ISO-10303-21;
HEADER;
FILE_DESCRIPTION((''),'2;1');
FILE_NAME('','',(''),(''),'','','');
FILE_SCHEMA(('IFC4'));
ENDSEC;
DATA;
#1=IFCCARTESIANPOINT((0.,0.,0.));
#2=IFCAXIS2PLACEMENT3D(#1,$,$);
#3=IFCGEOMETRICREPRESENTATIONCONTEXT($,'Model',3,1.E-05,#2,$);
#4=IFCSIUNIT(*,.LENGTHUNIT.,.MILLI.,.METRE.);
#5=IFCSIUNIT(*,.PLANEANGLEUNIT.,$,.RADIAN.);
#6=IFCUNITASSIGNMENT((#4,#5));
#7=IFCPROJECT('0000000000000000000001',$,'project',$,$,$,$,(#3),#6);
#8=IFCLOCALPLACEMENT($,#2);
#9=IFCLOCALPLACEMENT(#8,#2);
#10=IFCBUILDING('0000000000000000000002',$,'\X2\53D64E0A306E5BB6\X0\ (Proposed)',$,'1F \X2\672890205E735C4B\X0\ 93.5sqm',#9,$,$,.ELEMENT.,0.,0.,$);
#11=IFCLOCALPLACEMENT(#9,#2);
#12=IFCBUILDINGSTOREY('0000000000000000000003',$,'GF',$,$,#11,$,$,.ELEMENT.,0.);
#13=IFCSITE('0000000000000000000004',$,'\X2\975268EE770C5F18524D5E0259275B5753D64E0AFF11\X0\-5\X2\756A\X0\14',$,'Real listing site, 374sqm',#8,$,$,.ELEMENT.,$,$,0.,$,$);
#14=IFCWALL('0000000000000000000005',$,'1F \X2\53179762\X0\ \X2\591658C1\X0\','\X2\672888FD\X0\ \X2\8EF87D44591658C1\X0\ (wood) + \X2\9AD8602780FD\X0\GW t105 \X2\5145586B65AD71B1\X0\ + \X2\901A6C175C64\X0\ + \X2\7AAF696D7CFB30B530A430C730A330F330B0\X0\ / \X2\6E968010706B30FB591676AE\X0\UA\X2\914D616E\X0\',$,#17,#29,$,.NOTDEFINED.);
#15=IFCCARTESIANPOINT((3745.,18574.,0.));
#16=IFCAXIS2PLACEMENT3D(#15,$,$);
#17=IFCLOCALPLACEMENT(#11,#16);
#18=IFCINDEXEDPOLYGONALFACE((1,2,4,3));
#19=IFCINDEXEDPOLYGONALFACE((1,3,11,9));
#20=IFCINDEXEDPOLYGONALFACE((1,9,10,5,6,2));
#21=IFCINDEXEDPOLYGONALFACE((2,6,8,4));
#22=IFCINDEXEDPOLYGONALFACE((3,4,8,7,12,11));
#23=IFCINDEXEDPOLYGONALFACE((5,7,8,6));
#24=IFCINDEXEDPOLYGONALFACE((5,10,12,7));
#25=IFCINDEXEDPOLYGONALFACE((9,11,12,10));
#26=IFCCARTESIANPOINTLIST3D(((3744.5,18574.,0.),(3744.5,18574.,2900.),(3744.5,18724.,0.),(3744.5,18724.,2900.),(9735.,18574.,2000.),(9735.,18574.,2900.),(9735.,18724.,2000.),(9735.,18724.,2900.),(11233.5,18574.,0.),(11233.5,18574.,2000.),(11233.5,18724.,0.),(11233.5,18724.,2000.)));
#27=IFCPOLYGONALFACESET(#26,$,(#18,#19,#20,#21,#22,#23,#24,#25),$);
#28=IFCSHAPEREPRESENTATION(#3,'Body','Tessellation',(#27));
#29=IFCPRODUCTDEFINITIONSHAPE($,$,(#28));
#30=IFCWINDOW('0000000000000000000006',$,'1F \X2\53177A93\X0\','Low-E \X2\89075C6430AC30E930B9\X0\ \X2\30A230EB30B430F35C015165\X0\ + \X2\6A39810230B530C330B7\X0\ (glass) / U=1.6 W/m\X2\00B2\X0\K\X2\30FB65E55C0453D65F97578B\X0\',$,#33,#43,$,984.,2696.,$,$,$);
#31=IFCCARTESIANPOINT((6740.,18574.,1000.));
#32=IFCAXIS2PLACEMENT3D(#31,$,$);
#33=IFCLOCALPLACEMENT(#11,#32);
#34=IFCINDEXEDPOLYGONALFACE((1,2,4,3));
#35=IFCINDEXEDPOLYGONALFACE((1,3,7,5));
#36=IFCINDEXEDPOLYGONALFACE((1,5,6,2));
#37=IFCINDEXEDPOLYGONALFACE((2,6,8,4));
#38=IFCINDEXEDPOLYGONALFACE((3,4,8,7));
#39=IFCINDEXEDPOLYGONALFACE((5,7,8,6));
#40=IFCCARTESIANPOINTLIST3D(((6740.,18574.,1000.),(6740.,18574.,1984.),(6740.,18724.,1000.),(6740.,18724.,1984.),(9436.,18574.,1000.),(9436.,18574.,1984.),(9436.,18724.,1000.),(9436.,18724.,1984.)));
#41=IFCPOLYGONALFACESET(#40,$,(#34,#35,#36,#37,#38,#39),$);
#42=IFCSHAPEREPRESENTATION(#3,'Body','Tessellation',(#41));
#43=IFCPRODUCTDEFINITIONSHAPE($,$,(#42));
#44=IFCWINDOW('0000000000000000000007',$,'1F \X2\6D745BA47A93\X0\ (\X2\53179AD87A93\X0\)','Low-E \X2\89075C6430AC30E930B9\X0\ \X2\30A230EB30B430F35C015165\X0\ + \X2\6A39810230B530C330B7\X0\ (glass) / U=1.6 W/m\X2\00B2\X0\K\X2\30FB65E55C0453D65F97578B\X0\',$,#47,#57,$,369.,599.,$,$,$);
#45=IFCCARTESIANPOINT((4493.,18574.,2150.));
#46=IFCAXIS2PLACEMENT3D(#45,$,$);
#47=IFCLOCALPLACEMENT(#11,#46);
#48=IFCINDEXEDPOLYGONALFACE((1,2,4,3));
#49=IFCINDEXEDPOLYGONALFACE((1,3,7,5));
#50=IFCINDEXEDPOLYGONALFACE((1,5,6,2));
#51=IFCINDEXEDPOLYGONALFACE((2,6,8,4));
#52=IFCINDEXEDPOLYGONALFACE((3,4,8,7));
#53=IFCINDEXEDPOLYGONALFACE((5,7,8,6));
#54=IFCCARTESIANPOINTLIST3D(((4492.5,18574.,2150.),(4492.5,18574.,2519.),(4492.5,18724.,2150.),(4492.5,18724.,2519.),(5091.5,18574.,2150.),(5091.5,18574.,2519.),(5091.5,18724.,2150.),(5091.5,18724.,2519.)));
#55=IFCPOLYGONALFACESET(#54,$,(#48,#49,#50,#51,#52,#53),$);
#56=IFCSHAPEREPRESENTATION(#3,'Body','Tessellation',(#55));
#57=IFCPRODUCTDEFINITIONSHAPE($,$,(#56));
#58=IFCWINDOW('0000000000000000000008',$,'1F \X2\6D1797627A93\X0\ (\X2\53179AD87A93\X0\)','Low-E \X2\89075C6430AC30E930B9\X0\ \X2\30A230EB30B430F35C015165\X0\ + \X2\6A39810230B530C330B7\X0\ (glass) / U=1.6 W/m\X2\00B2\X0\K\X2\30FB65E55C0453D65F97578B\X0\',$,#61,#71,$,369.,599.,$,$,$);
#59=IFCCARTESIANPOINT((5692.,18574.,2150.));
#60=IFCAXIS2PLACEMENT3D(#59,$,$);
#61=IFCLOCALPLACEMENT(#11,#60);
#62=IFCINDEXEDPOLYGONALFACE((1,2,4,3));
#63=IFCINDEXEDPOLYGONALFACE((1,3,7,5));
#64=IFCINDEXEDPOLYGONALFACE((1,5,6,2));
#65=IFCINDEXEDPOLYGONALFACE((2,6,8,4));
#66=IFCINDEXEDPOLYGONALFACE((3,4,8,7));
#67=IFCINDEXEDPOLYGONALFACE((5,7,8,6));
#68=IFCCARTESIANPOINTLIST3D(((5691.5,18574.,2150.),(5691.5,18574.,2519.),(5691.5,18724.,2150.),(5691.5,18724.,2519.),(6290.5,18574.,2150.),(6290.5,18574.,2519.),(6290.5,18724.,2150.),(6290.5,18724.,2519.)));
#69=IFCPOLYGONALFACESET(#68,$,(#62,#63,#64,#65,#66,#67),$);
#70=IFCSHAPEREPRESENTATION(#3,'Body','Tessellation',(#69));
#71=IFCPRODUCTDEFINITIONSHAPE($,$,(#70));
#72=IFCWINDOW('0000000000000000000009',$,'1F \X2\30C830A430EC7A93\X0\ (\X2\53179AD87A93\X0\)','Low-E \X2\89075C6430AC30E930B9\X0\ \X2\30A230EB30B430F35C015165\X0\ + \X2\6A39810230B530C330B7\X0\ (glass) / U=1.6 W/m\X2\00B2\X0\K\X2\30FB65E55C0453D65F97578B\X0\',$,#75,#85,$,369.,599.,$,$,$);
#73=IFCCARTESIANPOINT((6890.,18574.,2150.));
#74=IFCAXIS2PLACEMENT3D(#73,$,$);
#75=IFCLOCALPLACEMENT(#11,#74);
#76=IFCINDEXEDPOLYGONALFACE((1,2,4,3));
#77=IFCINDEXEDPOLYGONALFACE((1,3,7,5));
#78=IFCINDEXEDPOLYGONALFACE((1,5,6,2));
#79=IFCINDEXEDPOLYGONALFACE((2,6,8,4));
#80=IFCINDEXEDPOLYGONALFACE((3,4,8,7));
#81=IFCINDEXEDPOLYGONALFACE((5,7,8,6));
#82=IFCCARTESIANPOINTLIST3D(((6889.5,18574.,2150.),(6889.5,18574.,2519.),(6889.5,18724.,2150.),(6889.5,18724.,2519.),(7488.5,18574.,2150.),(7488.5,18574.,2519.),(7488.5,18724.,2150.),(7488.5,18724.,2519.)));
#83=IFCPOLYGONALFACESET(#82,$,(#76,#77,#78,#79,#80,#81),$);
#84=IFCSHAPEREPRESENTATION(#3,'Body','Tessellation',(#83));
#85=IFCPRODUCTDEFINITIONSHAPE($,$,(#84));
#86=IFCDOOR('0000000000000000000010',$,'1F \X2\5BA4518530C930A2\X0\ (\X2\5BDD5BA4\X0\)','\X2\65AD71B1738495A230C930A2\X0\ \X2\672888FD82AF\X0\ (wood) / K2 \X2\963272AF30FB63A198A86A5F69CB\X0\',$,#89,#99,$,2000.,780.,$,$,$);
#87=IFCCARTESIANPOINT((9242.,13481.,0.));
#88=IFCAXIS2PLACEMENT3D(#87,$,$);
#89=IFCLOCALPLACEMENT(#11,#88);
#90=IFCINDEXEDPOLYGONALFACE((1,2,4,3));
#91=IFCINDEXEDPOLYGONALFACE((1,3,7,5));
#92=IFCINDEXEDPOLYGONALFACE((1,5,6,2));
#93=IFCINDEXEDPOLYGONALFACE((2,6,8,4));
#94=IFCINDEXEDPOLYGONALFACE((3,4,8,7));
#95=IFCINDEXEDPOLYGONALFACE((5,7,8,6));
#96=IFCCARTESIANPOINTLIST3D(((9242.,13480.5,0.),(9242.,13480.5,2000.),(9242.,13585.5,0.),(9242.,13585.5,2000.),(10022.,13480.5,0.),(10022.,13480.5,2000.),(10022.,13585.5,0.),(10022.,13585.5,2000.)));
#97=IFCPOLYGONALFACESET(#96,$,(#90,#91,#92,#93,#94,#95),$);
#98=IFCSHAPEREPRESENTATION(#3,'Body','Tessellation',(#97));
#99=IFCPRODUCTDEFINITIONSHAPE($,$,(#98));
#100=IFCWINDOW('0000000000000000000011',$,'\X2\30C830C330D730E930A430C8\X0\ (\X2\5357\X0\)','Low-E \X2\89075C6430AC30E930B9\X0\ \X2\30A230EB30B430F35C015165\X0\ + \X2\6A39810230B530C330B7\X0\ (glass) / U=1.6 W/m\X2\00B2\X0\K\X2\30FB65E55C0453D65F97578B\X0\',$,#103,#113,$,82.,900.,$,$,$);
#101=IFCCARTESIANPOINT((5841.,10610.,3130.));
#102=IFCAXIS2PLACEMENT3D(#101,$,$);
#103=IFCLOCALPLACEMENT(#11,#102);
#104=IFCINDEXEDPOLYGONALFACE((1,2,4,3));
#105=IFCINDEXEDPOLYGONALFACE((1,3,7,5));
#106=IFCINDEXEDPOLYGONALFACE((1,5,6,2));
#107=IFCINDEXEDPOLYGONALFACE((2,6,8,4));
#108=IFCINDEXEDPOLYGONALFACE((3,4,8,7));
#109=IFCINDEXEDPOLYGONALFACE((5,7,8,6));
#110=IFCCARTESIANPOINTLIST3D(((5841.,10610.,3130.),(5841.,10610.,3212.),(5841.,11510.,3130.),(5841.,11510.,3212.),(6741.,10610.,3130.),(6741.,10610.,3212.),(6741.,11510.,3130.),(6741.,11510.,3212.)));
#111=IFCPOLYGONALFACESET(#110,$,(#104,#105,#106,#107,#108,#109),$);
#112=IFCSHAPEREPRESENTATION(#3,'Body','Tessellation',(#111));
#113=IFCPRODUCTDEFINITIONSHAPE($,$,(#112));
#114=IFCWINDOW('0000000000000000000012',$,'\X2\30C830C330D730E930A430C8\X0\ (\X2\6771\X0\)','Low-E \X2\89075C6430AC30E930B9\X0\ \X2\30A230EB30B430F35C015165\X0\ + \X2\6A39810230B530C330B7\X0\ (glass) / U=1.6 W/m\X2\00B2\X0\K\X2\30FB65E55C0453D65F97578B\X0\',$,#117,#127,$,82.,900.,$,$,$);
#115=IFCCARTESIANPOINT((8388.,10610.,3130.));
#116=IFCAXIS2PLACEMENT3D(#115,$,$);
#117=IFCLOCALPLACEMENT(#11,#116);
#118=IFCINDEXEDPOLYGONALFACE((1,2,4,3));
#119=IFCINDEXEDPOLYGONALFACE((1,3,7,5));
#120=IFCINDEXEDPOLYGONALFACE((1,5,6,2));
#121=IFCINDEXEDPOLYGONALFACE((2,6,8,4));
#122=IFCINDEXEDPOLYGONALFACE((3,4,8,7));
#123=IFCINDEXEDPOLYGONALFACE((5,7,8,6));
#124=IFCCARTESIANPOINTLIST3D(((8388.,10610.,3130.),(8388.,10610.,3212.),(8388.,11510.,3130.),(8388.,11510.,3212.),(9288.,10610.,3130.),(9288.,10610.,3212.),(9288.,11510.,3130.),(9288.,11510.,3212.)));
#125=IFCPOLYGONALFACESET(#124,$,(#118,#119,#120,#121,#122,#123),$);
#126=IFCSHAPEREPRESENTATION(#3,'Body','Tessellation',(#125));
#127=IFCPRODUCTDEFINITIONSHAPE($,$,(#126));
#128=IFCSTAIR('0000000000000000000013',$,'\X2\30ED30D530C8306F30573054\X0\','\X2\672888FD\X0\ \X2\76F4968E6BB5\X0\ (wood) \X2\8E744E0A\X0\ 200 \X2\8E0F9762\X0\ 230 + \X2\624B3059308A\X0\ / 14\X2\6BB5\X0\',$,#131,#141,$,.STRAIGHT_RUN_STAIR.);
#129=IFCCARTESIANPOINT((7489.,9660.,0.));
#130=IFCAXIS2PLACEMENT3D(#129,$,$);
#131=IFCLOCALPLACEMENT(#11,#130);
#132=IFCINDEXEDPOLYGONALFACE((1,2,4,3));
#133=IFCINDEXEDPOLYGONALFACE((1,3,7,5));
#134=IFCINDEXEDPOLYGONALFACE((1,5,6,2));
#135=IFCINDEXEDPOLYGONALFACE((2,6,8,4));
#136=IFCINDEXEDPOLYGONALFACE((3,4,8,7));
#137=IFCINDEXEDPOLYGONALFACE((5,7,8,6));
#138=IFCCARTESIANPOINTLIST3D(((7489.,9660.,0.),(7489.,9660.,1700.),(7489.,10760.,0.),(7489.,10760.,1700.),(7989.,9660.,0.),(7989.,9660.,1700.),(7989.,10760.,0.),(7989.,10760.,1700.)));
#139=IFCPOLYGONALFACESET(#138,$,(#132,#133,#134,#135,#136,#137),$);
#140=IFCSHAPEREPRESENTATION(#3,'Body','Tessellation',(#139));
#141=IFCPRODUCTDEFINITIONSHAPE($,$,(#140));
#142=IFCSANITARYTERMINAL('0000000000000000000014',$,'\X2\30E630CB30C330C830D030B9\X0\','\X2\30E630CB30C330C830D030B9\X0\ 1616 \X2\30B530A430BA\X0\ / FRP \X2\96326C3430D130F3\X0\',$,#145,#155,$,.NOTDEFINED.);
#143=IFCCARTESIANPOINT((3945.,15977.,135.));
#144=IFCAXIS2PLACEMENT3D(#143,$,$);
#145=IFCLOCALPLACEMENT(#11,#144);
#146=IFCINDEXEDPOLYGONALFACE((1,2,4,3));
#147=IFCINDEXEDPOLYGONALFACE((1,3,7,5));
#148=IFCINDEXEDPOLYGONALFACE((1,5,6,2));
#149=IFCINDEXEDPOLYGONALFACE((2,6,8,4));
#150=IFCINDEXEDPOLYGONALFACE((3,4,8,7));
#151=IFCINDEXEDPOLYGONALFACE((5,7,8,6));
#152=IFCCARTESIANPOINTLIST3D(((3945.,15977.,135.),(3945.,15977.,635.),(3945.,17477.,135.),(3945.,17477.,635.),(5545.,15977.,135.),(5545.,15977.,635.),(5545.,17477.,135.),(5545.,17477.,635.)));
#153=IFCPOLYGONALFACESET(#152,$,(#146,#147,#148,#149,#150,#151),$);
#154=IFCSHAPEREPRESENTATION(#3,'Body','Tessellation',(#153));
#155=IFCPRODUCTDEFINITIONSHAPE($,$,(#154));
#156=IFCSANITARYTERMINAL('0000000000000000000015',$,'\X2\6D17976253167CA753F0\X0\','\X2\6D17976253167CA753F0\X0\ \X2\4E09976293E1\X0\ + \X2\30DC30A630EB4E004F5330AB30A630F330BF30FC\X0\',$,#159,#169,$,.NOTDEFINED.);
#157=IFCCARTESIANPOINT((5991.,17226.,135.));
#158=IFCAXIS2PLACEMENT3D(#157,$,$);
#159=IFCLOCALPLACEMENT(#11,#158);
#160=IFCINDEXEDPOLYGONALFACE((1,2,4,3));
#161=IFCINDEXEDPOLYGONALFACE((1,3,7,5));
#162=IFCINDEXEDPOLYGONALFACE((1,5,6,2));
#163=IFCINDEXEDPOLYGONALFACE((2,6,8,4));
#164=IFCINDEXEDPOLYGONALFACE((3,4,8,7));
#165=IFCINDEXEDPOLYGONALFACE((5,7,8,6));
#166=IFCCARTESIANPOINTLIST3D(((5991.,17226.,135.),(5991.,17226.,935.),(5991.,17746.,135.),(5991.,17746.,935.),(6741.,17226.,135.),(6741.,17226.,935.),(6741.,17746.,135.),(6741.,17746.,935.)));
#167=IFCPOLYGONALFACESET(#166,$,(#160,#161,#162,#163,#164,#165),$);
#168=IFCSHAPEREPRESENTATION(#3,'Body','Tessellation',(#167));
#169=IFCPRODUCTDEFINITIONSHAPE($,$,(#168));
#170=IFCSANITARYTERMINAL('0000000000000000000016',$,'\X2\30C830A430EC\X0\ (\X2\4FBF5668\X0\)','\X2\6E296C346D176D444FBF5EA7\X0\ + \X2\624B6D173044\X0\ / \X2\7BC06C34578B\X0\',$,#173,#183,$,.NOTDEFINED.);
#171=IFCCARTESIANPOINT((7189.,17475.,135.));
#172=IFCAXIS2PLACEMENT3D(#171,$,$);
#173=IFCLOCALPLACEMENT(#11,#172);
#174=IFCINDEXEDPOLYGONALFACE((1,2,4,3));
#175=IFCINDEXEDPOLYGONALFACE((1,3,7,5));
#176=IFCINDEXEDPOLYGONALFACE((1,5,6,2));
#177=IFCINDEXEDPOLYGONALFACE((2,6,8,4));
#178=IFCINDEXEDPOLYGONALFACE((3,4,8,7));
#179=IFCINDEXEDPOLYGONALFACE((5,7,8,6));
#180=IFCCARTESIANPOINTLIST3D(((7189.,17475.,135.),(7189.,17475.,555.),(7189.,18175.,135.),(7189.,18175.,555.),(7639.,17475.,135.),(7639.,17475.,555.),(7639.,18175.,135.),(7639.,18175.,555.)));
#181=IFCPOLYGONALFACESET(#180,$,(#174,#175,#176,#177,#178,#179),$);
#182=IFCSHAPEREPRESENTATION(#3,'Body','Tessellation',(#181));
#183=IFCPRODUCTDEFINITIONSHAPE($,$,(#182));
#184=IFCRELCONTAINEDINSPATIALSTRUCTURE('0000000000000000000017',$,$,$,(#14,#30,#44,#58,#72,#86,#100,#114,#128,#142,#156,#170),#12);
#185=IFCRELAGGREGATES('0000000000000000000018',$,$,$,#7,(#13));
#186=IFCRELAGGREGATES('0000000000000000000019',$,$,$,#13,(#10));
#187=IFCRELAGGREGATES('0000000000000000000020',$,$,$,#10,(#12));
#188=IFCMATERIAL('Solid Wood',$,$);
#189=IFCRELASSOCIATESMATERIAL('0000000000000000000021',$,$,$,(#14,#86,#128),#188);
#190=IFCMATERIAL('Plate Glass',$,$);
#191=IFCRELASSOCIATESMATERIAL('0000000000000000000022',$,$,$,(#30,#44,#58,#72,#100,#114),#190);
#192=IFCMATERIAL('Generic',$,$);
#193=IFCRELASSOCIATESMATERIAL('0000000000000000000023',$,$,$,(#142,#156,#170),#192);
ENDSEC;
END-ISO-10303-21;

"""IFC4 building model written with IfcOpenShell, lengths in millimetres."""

from ifc_helpers import new_model, si_unit, frame, frame_2d, origin, place, context, project, spatial, rectangle, extrude, material, element, fill, save


model = new_model("IFC4")

# Units and contexts
model_context = context("Model", 3, precision=1e-05, world=origin())
ifc_project = project(units=[si_unit("LENGTHUNIT", "METRE", prefix="MILLI"), si_unit("PLANEANGLEUNIT", "RADIAN")], contexts=[model_context])

# Site, building, storey
site_placement = place(None, origin())
site = spatial("IfcSite", under=ifc_project, at=site_placement, Name="青森県弘前市大字取上１-5番14", ObjectType="Real listing site, 374sqm", CompositionType="ELEMENT", RefElevation=0.0)
building_placement = place(site_placement, origin())
building = spatial("IfcBuilding", under=site, at=building_placement, Name="取上の家 (Proposed)", ObjectType="1F 木造平屋 93.5sqm", CompositionType="ELEMENT", ElevationOfRefHeight=0.0, ElevationOfTerrain=0.0)
storey_placement = place(building_placement, origin())
storey = spatial("IfcBuildingStorey", under=building, at=storey_placement, Name="GF", CompositionType="ELEMENT", Elevation=0.0)

# Shared definitions
ifc_material_1 = material(Name="Solid Wood")

# Wall, openings, windows
wall_1_placement = place(storey_placement, frame((3745.0, 18574.0, 0.0)))
wall_1 = element("IfcWall", 1, at=wall_1_placement, inside=storey, material=ifc_material_1, Name="1F 北面 外壁", Description="木製 軸組外壁 (wood) + 高性能GW t105 充填断熱 + 通気層 + 窯業系サイディング / 準耐火・外皮UA配慮", PredefinedType="NOTDEFINED", context=model_context, shape_type="SweptSolid", body=[
    extrude(rectangle(XDim=7489.0, YDim=150.0, at=frame_2d((3744.0, 75.0))), frame((3745.0, 18574.0, 0.0)), (0.0, 0.0, 1.0), 2900.0),
])
opening_1_placement = place(storey_placement, frame((6740.0, 18574.0, 1000.0)))
opening_1 = element("IfcOpeningElement", 2, at=opening_1_placement, cuts=wall_1, PredefinedType="NOTDEFINED", context=model_context, shape_type="SweptSolid", body=[
    extrude(rectangle(XDim=2696.0, YDim=150.0, at=frame_2d((1348.0, 75.0))), frame((6740.0, 18574.0, 1000.0)), (0.0, 0.0, 1.0), 984.0),
])
opening_2_placement = place(storey_placement, frame((4493.0, 18574.0, 2150.0)))
opening_2 = element("IfcOpeningElement", 3, at=opening_2_placement, cuts=wall_1, PredefinedType="NOTDEFINED", context=model_context, shape_type="SweptSolid", body=[
    extrude(rectangle(XDim=599.0, YDim=150.0, at=frame_2d((299.0, 75.0))), frame((4493.0, 18574.0, 2150.0)), (0.0, 0.0, 1.0), 369.0),
])
opening_3_placement = place(storey_placement, frame((5692.0, 18574.0, 2150.0)))
opening_3 = element("IfcOpeningElement", 4, at=opening_3_placement, cuts=wall_1, PredefinedType="NOTDEFINED", context=model_context, shape_type="SweptSolid", body=[
    extrude(rectangle(XDim=599.0, YDim=150.0, at=frame_2d((299.0, 75.0))), frame((5692.0, 18574.0, 2150.0)), (0.0, 0.0, 1.0), 369.0),
])
opening_4_placement = place(storey_placement, frame((6890.0, 18574.0, 2150.0)))
opening_4 = element("IfcOpeningElement", 5, at=opening_4_placement, cuts=wall_1, PredefinedType="NOTDEFINED", context=model_context, shape_type="SweptSolid", body=[
    extrude(rectangle(XDim=599.0, YDim=150.0, at=frame_2d((299.0, 75.0))), frame((6890.0, 18574.0, 2150.0)), (0.0, 0.0, 1.0), 369.0),
])
ifc_material_2 = material(Name="Plate Glass")
window_1_placement = place(storey_placement, frame((6740.0, 18574.0, 1000.0)))
window_1 = element("IfcWindow", 6, at=window_1_placement, inside=storey, material=ifc_material_2, Name="1F 北窓", Description="Low-E 複層ガラス アルゴン封入 + 樹脂サッシ (glass) / U=1.6 W/m²K・日射取得型", OverallHeight=984.0, OverallWidth=2696.0, context=model_context, shape_type="SweptSolid", body=[
    extrude(rectangle(XDim=2696.0, YDim=150.0, at=frame_2d((1348.0, 75.0))), frame((6740.0, 18574.0, 1000.0)), (0.0, 0.0, 1.0), 984.0),
])
fill(opening_1, window_1)
window_2_placement = place(storey_placement, frame((4493.0, 18574.0, 2150.0)))
window_2 = element("IfcWindow", 7, at=window_2_placement, inside=storey, material=ifc_material_2, Name="1F 浴室窓 (北高窓)", Description="Low-E 複層ガラス アルゴン封入 + 樹脂サッシ (glass) / U=1.6 W/m²K・日射取得型", OverallHeight=369.0, OverallWidth=599.0, context=model_context, shape_type="SweptSolid", body=[
    extrude(rectangle(XDim=599.0, YDim=150.0, at=frame_2d((299.0, 75.0))), frame((4493.0, 18574.0, 2150.0)), (0.0, 0.0, 1.0), 369.0),
])
fill(opening_2, window_2)
window_3_placement = place(storey_placement, frame((5692.0, 18574.0, 2150.0)))
window_3 = element("IfcWindow", 8, at=window_3_placement, inside=storey, material=ifc_material_2, Name="1F 洗面窓 (北高窓)", Description="Low-E 複層ガラス アルゴン封入 + 樹脂サッシ (glass) / U=1.6 W/m²K・日射取得型", OverallHeight=369.0, OverallWidth=599.0, context=model_context, shape_type="SweptSolid", body=[
    extrude(rectangle(XDim=599.0, YDim=150.0, at=frame_2d((299.0, 75.0))), frame((5692.0, 18574.0, 2150.0)), (0.0, 0.0, 1.0), 369.0),
])
fill(opening_3, window_3)
window_4_placement = place(storey_placement, frame((6890.0, 18574.0, 2150.0)))
window_4 = element("IfcWindow", 9, at=window_4_placement, inside=storey, material=ifc_material_2, Name="1F トイレ窓 (北高窓)", Description="Low-E 複層ガラス アルゴン封入 + 樹脂サッシ (glass) / U=1.6 W/m²K・日射取得型", OverallHeight=369.0, OverallWidth=599.0, context=model_context, shape_type="SweptSolid", body=[
    extrude(rectangle(XDim=599.0, YDim=150.0, at=frame_2d((299.0, 75.0))), frame((6890.0, 18574.0, 2150.0)), (0.0, 0.0, 1.0), 369.0),
])
fill(opening_4, window_4)

# Door
door_1_placement = place(storey_placement, frame((9242.0, 13481.0, 0.0)))
element("IfcDoor", 10, at=door_1_placement, inside=storey, material=ifc_material_1, Name="1F 室内ドア (寝室)", Description="断熱玄関ドア 木製芯 (wood) / K2 防犯・採風機構", OverallHeight=2000.0, OverallWidth=780.0, context=model_context, shape_type="SweptSolid", body=[
    extrude(rectangle(XDim=780.0, YDim=105.0, at=frame_2d((390.0, 52.0))), frame((9242.0, 13481.0, 0.0)), (0.0, 0.0, 1.0), 2000.0),
])

# Windows
window_5_placement = place(storey_placement, frame((5841.0, 10610.0, 3130.0)))
element("IfcWindow", 11, at=window_5_placement, inside=storey, material=ifc_material_2, Name="トップライト (南)", Description="Low-E 複層ガラス アルゴン封入 + 樹脂サッシ (glass) / U=1.6 W/m²K・日射取得型", OverallHeight=82.0, OverallWidth=900.0, context=model_context, shape_type="SweptSolid", body=[
    extrude(rectangle(XDim=900.0, YDim=900.0, at=frame_2d((450.0, 450.0))), frame((5841.0, 10610.0, 3130.0)), (0.0, 0.0, 1.0), 82.0),
])
window_6_placement = place(storey_placement, frame((8388.0, 10610.0, 3130.0)))
element("IfcWindow", 12, at=window_6_placement, inside=storey, material=ifc_material_2, Name="トップライト (東)", Description="Low-E 複層ガラス アルゴン封入 + 樹脂サッシ (glass) / U=1.6 W/m²K・日射取得型", OverallHeight=82.0, OverallWidth=900.0, context=model_context, shape_type="SweptSolid", body=[
    extrude(rectangle(XDim=900.0, YDim=900.0, at=frame_2d((450.0, 450.0))), frame((8388.0, 10610.0, 3130.0)), (0.0, 0.0, 1.0), 82.0),
])

# Stair
stair_placement = place(storey_placement, frame((7489.0, 9660.0, 0.0)))
element("IfcStair", 13, at=stair_placement, inside=storey, material=ifc_material_1, Name="ロフトはしご", Description="木製 直階段 (wood) 蹴上 200 踏面 230 + 手すり / 14段", PredefinedType="STRAIGHT_RUN_STAIR", context=model_context, shape_type="SweptSolid", body=[
    extrude(rectangle(XDim=500.0, YDim=1100.0, at=frame_2d((250.0, 550.0))), frame((7489.0, 9660.0, 0.0)), (0.0, 0.0, 1.0), 1700.0),
])

# Sanitary terminals
ifc_material_3 = material(Name="Generic")
sanitary_terminal_1_placement = place(storey_placement, frame((3945.0, 15977.0, 135.0)))
element("IfcSanitaryTerminal", 14, at=sanitary_terminal_1_placement, inside=storey, material=ifc_material_3, Name="ユニットバス", Description="ユニットバス 1616 サイズ / FRP 防水パン", PredefinedType="NOTDEFINED", context=model_context, shape_type="SweptSolid", body=[
    extrude(rectangle(XDim=1600.0, YDim=1500.0, at=frame_2d((800.0, 750.0))), frame((3945.0, 15977.0, 135.0)), (0.0, 0.0, 1.0), 500.0),
])
sanitary_terminal_2_placement = place(storey_placement, frame((5991.0, 17226.0, 135.0)))
element("IfcSanitaryTerminal", 15, at=sanitary_terminal_2_placement, inside=storey, material=ifc_material_3, Name="洗面化粧台", Description="洗面化粧台 三面鏡 + ボウル一体カウンター", PredefinedType="NOTDEFINED", context=model_context, shape_type="SweptSolid", body=[
    extrude(rectangle(XDim=750.0, YDim=520.0, at=frame_2d((375.0, 260.0))), frame((5991.0, 17226.0, 135.0)), (0.0, 0.0, 1.0), 800.0),
])
sanitary_terminal_3_placement = place(storey_placement, frame((7189.0, 17475.0, 135.0)))
element("IfcSanitaryTerminal", 16, at=sanitary_terminal_3_placement, inside=storey, material=ifc_material_3, Name="トイレ (便器)", Description="温水洗浄便座 + 手洗い / 節水型", PredefinedType="NOTDEFINED", context=model_context, shape_type="SweptSolid", body=[
    extrude(rectangle(XDim=450.0, YDim=700.0, at=frame_2d((225.0, 350.0))), frame((7189.0, 17475.0, 135.0)), (0.0, 0.0, 1.0), 420.0),
])

save(model, "model.ifc")
